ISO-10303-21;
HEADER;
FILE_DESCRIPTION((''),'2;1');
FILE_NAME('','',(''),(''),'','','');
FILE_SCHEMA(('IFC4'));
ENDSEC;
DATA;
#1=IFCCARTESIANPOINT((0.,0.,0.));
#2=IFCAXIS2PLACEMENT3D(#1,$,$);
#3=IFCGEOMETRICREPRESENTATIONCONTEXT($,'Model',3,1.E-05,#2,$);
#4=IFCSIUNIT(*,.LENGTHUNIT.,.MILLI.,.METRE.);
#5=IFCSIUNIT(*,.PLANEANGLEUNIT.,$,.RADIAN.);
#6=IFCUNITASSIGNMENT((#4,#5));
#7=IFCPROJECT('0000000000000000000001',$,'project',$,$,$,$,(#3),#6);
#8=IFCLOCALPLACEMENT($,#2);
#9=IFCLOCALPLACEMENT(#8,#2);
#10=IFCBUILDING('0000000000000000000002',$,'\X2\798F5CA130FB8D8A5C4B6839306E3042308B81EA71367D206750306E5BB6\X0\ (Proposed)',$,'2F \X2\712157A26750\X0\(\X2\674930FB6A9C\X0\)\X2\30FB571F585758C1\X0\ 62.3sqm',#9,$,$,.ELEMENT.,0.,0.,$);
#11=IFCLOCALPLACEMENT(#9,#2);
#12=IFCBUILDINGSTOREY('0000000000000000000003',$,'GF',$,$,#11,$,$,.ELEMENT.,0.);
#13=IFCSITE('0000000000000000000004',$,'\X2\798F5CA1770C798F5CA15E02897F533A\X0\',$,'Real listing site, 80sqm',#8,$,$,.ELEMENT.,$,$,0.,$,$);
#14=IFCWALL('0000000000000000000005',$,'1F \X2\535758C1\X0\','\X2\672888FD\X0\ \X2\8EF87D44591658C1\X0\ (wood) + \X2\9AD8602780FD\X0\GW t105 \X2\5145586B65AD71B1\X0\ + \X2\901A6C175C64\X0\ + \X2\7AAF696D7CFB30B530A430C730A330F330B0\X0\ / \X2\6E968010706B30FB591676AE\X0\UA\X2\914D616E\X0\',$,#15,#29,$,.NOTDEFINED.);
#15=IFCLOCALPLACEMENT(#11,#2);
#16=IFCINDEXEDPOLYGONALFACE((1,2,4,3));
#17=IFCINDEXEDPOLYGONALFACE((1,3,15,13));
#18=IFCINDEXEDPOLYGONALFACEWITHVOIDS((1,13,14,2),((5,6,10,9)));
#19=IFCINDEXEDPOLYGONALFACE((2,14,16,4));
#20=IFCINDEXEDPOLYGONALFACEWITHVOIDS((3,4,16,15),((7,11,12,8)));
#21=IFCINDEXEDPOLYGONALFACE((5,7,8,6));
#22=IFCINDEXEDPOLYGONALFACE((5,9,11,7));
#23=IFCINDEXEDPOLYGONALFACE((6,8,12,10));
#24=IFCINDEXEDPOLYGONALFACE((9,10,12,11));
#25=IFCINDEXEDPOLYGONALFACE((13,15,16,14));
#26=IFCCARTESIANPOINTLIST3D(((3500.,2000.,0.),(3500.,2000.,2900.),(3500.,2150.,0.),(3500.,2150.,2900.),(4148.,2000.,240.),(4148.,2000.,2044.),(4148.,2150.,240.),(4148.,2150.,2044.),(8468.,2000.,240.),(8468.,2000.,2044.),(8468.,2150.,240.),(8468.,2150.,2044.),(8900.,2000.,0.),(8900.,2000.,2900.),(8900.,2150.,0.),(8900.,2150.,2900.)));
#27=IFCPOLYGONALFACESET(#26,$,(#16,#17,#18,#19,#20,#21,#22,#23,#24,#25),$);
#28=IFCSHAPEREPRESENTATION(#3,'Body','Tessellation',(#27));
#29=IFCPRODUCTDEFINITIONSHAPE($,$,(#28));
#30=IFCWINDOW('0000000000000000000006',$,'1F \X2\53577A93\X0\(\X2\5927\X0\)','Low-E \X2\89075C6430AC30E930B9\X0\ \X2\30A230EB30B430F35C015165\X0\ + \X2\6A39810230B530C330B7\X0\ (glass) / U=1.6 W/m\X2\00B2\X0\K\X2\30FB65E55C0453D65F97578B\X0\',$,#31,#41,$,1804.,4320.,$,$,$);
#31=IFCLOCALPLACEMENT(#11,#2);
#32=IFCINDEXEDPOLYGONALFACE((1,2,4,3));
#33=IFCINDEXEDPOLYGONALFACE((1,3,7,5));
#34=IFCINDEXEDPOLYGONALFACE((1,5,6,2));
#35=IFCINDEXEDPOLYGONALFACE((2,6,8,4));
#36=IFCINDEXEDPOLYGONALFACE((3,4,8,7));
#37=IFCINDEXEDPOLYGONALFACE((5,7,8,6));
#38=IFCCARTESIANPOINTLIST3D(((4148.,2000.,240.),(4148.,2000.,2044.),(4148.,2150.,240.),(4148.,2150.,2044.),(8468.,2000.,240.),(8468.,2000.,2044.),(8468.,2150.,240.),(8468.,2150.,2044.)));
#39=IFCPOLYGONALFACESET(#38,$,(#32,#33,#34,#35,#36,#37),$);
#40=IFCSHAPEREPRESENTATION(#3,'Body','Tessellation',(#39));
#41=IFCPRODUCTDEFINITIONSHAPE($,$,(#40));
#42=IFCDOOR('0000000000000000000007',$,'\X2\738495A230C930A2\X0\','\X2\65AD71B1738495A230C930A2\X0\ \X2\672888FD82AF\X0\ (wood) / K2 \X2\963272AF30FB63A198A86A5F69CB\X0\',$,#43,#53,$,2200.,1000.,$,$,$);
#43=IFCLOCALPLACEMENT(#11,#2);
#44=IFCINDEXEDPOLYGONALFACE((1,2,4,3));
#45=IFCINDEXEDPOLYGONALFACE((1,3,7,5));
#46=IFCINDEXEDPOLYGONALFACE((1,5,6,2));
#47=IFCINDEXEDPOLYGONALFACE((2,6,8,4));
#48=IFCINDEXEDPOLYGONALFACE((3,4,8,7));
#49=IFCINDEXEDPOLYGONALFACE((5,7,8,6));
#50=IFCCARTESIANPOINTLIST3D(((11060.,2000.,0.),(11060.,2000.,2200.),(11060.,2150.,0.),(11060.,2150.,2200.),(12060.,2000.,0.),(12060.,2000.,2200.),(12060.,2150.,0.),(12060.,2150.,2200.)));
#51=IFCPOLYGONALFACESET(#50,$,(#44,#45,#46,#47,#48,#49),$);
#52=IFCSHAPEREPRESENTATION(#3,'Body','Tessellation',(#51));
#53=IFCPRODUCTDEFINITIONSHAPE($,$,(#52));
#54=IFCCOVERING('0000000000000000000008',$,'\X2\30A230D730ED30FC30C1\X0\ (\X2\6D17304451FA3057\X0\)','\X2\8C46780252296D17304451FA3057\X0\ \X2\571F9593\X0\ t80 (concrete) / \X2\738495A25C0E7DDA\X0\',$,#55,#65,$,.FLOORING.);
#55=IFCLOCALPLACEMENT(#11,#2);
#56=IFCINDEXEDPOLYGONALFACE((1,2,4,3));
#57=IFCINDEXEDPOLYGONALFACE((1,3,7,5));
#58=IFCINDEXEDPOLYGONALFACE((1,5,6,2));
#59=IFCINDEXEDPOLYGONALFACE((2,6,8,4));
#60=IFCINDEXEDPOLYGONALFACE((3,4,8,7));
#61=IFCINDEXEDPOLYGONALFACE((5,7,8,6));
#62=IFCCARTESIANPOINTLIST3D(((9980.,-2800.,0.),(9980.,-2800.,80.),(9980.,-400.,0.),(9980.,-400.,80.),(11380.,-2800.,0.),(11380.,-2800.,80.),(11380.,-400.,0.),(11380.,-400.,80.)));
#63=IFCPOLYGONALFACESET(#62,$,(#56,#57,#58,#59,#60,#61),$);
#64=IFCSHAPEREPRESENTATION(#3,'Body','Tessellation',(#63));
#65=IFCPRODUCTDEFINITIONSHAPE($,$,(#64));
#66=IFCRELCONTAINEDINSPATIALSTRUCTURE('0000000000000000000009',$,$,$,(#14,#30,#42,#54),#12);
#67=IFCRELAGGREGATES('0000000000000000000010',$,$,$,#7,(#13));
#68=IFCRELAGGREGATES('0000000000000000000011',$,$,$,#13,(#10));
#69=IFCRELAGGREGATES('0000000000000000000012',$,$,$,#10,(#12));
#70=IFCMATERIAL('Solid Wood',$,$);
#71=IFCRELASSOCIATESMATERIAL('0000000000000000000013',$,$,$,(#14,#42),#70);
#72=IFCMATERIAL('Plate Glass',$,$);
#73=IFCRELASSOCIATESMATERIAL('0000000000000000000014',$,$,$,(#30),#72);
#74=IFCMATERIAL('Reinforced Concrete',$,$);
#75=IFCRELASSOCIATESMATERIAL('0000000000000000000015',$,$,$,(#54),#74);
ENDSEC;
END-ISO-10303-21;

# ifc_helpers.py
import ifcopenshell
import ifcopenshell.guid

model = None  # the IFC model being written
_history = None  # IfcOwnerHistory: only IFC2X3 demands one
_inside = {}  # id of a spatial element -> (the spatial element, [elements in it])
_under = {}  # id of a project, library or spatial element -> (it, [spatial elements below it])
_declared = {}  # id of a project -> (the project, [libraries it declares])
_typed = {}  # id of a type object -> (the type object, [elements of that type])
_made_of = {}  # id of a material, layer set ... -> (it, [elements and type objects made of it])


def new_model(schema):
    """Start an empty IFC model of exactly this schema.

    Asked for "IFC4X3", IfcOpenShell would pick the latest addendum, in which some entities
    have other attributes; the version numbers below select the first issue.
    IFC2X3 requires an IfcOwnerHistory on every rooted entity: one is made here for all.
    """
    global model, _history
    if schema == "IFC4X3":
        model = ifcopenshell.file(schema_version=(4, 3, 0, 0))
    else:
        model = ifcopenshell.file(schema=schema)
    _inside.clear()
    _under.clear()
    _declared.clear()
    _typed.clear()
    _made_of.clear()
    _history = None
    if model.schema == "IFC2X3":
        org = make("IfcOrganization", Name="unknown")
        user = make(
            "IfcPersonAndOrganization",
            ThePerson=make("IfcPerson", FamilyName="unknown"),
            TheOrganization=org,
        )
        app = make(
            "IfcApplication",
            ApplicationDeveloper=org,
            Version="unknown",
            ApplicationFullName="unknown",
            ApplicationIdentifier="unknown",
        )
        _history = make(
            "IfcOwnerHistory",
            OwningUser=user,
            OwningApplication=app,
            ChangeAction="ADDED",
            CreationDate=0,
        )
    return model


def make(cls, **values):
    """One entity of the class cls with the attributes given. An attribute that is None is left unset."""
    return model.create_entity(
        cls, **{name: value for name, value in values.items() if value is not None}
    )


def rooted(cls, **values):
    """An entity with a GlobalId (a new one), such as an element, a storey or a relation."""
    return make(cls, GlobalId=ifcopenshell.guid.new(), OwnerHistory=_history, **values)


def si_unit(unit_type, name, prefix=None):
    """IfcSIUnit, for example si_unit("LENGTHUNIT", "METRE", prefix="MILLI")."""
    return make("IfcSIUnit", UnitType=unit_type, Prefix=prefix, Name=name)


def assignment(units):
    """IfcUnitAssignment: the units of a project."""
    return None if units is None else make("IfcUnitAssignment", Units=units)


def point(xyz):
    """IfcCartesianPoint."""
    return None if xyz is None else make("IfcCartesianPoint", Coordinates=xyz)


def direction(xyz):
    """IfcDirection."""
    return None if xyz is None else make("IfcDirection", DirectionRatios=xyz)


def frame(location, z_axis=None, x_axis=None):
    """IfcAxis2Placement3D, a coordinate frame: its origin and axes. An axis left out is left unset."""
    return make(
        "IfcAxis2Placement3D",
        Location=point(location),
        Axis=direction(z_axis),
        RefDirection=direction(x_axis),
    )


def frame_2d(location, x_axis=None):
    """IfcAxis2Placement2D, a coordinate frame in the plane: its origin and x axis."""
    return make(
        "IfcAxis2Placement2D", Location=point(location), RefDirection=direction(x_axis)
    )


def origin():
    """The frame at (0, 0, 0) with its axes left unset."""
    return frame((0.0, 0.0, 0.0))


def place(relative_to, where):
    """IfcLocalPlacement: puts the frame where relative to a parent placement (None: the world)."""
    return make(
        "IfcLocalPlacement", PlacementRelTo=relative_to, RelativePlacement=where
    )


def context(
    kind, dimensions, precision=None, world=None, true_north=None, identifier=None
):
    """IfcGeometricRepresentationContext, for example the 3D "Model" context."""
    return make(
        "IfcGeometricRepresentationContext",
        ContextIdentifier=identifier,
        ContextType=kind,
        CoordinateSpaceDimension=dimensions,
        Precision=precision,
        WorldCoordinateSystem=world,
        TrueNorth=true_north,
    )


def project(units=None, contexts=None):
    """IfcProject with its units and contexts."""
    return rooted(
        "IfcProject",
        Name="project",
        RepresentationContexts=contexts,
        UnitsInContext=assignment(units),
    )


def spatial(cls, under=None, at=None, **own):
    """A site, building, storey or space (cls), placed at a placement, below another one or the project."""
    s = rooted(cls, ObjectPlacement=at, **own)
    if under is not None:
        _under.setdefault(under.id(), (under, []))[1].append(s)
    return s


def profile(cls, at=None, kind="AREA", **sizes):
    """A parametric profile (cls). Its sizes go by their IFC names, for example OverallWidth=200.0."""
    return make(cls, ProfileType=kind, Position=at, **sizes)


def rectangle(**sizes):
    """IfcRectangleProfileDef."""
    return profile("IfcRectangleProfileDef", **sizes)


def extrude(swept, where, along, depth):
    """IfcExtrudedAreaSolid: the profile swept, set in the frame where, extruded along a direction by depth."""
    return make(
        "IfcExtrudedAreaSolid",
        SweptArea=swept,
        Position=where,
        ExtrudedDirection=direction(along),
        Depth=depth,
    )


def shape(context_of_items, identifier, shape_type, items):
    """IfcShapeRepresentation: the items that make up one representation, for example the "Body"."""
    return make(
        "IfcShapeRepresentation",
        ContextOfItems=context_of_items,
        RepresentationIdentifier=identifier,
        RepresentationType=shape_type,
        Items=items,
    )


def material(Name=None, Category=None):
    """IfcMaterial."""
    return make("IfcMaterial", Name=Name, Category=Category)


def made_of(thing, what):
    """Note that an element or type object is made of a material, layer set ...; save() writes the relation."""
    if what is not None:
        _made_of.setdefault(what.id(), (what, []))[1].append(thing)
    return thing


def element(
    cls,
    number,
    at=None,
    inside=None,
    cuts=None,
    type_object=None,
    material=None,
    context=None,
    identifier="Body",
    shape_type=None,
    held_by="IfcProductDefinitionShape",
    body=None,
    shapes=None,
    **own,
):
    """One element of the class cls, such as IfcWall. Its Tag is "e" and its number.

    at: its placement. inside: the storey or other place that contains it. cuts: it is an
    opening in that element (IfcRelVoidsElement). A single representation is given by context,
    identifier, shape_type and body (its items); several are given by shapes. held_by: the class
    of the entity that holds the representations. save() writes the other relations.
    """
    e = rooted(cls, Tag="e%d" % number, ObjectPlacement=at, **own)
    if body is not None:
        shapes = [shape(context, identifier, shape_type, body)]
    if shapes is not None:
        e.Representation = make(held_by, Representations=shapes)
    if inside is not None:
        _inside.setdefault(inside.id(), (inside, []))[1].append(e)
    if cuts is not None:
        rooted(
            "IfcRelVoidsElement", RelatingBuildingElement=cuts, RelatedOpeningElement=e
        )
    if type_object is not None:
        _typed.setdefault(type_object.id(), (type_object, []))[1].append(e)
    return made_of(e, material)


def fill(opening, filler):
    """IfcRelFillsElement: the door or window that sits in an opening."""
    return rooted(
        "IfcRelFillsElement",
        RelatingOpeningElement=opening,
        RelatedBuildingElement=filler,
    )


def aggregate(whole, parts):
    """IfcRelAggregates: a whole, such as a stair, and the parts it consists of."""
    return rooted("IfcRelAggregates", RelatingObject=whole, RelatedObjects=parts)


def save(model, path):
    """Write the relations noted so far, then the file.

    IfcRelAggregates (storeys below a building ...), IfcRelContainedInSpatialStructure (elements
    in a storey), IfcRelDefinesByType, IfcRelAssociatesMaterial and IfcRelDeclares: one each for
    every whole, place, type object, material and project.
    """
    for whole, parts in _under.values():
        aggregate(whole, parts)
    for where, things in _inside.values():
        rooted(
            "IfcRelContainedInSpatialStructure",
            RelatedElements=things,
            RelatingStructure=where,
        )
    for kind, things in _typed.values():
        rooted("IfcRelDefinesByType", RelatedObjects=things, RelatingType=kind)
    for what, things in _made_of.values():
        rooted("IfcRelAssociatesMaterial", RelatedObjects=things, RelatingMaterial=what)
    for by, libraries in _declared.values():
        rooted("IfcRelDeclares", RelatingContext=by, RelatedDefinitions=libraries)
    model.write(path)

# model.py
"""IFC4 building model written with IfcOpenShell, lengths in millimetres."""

from ifc_helpers import new_model, si_unit, frame, frame_2d, origin, place, context, project, spatial, rectangle, extrude, material, element, fill, save


model = new_model("IFC4")

# Units and contexts
model_context = context("Model", 3, precision=1e-05, world=origin())
ifc_project = project(units=[si_unit("LENGTHUNIT", "METRE", prefix="MILLI"), si_unit("PLANEANGLEUNIT", "RADIAN")], contexts=[model_context])

# Site, building, storey
site_placement = place(None, origin())
site = spatial("IfcSite", under=ifc_project, at=site_placement, Name="福岡県福岡市西区", ObjectType="Real listing site, 80sqm", CompositionType="ELEMENT", RefElevation=0.0)
building_placement = place(site_placement, origin())
building = spatial("IfcBuilding", under=site, at=building_placement, Name="福岡・越屋根のある自然素材の家 (Proposed)", ObjectType="2F 無垢材(杉・檜)・土塗壁 62.3sqm", CompositionType="ELEMENT", ElevationOfRefHeight=0.0, ElevationOfTerrain=0.0)
storey_placement = place(building_placement, origin())
storey = spatial("IfcBuildingStorey", under=building, at=storey_placement, Name="GF", CompositionType="ELEMENT", Elevation=0.0)

# Shared definitions
ifc_material_1 = material(Name="Solid Wood")

# Shared definitions
ifc_material_2 = material(Name="Reinforced Concrete")

# Wall, openings, window, door
wall_1_placement = place(storey_placement, frame((1750.0, 1000.0, 0.0)))
wall_1 = element("IfcWall", 1, at=wall_1_placement, inside=storey, material=ifc_material_1, Name="1F 南壁", Description="木製 軸組外壁 (wood) + 高性能GW t105 充填断熱 + 通気層 + 窯業系サイディング / 準耐火・外皮UA配慮", PredefinedType="NOTDEFINED", context=model_context, shape_type="SweptSolid", body=[
    extrude(rectangle(XDim=5400.0, YDim=150.0, at=frame_2d((2700.0, 75.0))), frame((1750.0, 1000.0, 0.0)), (0.0, 0.0, 1.0), 2900.0),
])
opening_1_placement = place(storey_placement, frame((2074.0, 1000.0, 120.0)))
opening_1 = element("IfcOpeningElement", 2, at=opening_1_placement, cuts=wall_1, PredefinedType="NOTDEFINED", context=model_context, shape_type="SweptSolid", body=[
    extrude(rectangle(XDim=4320.0, YDim=150.0, at=frame_2d((2160.0, 75.0))), frame((2074.0, 1000.0, 120.0)), (0.0, 0.0, 1.0), 1804.0),
])
opening_2_placement = place(storey_placement, frame((5530.0, 1000.0, 0.0)))
opening_2 = element("IfcOpeningElement", 3, at=opening_2_placement, cuts=wall_1, PredefinedType="NOTDEFINED", context=model_context, shape_type="SweptSolid", body=[
    extrude(rectangle(XDim=1000.0, YDim=150.0, at=frame_2d((500.0, 75.0))), frame((5530.0, 1000.0, 0.0)), (0.0, 0.0, 1.0), 2200.0),
])
ifc_material_3 = material(Name="Plate Glass")
window_1_placement = place(storey_placement, frame((2074.0, 1000.0, 120.0)))
window_1 = element("IfcWindow", 4, at=window_1_placement, inside=storey, material=ifc_material_3, Name="1F 南窓(大)", Description="Low-E 複層ガラス アルゴン封入 + 樹脂サッシ (glass) / U=1.6 W/m²K・日射取得型", OverallHeight=1804.0, OverallWidth=4320.0, context=model_context, shape_type="SweptSolid", body=[
    extrude(rectangle(XDim=4320.0, YDim=150.0, at=frame_2d((2160.0, 75.0))), frame((2074.0, 1000.0, 120.0)), (0.0, 0.0, 1.0), 1804.0),
])
fill(opening_1, window_1)
door_1_placement = place(storey_placement, frame((5530.0, 1000.0, 0.0)))
door_1 = element("IfcDoor", 5, at=door_1_placement, inside=storey, material=ifc_material_1, Name="玄関ドア", Description="断熱玄関ドア 木製芯 (wood) / K2 防犯・採風機構", OverallHeight=2200.0, OverallWidth=1000.0, context=model_context, shape_type="SweptSolid", body=[
    extrude(rectangle(XDim=1000.0, YDim=150.0, at=frame_2d((500.0, 75.0))), frame((5530.0, 1000.0, 0.0)), (0.0, 0.0, 1.0), 2200.0),
])
fill(opening_2, door_1)

# Covering
covering_1_placement = place(storey_placement, frame((4990.0, -1400.0, 0.0)))
element("IfcCovering", 6, at=covering_1_placement, inside=storey, material=ifc_material_2, Name="アプローチ (洗い出し)", Description="豆砂利洗い出し 土間 t80 (concrete) / 玄関導線", PredefinedType="FLOORING", context=model_context, shape_type="SweptSolid", body=[
    extrude(rectangle(XDim=1400.0, YDim=2400.0, at=frame_2d((700.0, 1200.0))), frame((4990.0, -1400.0, 0.0)), (0.0, 0.0, 1.0), 80.0),
])

save(model, "model.ifc")
